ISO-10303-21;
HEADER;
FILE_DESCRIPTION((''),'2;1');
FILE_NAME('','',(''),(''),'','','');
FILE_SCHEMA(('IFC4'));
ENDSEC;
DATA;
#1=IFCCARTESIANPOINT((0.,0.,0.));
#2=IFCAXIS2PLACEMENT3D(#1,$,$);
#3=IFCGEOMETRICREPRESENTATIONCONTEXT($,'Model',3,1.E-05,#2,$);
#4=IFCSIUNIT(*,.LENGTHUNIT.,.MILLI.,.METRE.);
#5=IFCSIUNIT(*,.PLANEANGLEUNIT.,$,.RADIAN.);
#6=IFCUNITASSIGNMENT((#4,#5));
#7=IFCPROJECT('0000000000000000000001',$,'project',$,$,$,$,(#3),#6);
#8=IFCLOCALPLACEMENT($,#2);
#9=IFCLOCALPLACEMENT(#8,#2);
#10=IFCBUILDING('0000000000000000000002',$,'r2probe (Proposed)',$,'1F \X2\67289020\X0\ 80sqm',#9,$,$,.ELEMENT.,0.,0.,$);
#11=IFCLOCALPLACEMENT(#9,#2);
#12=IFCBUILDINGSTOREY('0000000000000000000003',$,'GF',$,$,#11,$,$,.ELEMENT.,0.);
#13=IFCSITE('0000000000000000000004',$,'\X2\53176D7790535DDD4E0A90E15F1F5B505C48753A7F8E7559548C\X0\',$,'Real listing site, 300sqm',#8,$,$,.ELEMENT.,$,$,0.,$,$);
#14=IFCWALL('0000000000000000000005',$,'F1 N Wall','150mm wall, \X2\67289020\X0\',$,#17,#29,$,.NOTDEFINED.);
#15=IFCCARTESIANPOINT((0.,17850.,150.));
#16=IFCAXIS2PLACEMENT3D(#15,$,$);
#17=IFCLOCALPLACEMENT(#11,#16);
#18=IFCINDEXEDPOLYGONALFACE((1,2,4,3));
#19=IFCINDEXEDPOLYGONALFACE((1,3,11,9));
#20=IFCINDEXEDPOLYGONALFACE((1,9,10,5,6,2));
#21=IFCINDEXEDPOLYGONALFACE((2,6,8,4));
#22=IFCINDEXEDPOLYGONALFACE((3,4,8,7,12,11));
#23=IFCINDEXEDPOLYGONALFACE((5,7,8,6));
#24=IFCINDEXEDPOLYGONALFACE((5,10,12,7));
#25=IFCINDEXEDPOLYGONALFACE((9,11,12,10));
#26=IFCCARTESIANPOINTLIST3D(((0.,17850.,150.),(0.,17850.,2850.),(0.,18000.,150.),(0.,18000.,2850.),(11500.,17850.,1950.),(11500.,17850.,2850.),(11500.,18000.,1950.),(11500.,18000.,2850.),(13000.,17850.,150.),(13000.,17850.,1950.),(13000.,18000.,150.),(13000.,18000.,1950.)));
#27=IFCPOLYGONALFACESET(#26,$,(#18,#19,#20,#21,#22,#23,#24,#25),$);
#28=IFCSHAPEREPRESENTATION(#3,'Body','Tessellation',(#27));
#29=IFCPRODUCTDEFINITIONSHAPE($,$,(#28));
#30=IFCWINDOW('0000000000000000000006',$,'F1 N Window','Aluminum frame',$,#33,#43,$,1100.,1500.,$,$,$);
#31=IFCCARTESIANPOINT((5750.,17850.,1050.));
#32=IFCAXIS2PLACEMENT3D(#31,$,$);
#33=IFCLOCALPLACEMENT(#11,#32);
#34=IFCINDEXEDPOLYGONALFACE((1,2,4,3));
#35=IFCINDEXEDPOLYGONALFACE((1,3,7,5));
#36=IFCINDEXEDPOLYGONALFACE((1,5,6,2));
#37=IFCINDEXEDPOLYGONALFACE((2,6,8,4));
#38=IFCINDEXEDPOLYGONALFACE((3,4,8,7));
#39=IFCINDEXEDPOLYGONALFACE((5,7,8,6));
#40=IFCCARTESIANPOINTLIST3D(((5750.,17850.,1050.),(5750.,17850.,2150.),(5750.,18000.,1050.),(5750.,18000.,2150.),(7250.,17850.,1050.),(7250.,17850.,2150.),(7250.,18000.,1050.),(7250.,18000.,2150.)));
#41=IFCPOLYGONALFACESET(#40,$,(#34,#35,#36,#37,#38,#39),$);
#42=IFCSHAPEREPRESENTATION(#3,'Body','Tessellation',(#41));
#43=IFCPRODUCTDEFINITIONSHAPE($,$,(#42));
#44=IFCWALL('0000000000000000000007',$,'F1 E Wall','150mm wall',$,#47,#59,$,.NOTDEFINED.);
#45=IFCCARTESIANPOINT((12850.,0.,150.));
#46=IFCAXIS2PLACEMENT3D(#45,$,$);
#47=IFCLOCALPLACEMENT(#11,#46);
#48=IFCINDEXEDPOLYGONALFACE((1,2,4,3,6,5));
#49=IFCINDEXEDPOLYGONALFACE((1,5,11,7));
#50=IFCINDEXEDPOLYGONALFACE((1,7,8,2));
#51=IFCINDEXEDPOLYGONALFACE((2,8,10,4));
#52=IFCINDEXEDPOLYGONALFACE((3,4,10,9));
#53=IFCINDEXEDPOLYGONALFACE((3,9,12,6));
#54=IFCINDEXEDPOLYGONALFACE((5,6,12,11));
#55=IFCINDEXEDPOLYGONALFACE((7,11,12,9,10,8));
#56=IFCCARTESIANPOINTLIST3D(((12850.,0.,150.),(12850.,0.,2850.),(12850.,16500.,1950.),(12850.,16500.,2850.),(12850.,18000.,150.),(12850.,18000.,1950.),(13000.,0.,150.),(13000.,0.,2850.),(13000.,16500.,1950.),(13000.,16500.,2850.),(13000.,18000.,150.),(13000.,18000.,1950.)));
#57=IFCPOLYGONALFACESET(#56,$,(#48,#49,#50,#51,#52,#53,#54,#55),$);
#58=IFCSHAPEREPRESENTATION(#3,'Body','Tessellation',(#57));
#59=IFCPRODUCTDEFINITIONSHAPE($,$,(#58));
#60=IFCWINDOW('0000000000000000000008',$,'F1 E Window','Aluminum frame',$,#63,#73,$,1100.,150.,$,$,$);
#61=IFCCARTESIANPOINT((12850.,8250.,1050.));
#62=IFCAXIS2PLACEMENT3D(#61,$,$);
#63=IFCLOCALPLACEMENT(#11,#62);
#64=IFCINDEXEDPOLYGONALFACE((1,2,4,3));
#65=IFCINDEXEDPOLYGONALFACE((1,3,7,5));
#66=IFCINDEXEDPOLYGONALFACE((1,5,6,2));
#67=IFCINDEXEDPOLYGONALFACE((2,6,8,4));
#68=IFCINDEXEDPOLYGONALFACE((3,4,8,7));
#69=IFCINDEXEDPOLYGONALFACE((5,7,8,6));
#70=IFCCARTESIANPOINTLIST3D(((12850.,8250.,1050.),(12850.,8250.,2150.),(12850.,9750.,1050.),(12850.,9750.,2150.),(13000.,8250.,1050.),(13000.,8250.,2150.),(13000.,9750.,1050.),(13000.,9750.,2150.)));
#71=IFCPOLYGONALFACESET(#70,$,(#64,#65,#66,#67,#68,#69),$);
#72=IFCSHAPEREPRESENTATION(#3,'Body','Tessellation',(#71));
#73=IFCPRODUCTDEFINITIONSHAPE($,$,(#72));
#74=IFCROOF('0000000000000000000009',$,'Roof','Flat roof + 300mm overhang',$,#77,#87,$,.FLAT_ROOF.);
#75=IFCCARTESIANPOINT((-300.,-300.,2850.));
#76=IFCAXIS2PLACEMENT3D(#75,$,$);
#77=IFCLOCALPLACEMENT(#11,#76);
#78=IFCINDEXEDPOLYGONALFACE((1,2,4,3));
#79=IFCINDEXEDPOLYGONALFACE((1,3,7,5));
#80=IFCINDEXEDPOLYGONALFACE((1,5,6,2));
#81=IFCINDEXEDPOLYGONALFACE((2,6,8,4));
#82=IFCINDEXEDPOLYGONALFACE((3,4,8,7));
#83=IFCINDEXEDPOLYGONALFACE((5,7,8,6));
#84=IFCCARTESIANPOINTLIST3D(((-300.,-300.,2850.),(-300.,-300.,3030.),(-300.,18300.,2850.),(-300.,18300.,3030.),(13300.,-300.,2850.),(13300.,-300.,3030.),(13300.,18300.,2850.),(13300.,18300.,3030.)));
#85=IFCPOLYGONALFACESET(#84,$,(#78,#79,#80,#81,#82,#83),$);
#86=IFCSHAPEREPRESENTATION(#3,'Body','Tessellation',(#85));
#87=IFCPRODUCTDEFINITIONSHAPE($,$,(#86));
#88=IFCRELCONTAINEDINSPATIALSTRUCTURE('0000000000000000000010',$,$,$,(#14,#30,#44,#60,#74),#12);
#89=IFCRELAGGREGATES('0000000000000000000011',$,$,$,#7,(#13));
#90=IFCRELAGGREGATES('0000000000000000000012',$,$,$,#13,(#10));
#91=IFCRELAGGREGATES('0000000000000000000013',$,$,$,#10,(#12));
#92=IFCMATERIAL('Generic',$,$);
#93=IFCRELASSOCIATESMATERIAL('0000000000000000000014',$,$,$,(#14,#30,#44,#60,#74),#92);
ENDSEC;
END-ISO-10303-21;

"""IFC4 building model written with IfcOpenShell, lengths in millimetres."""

from ifc_helpers import new_model, si_unit, frame, frame_2d, origin, place, context, project, spatial, rectangle, extrude, material, element, fill, save


model = new_model("IFC4")

# Units and contexts
model_context = context("Model", 3, precision=1e-05, world=origin())
ifc_project = project(units=[si_unit("LENGTHUNIT", "METRE", prefix="MILLI"), si_unit("PLANEANGLEUNIT", "RADIAN")], contexts=[model_context])

# Site, building, storey
site_placement = place(None, origin())
site = spatial("IfcSite", under=ifc_project, at=site_placement, Name="北海道川上郡弟子屈町美留和", ObjectType="Real listing site, 300sqm", CompositionType="ELEMENT", RefElevation=0.0)
building_placement = place(site_placement, origin())
building = spatial("IfcBuilding", under=site, at=building_placement, Name="r2probe (Proposed)", ObjectType="1F 木造 80sqm", CompositionType="ELEMENT", ElevationOfRefHeight=0.0, ElevationOfTerrain=0.0)
storey_placement = place(building_placement, origin())
storey = spatial("IfcBuildingStorey", under=building, at=storey_placement, Name="GF", CompositionType="ELEMENT", Elevation=0.0)

# Wall, opening, window
ifc_material_1 = material(Name="Generic")
wall_1_placement = place(storey_placement, frame((0.0, 17850.0, 150.0)))
wall_1 = element("IfcWall", 1, at=wall_1_placement, inside=storey, material=ifc_material_1, Name="F1 N Wall", Description="150mm wall, 木造", PredefinedType="NOTDEFINED", context=model_context, shape_type="SweptSolid", body=[
    extrude(rectangle(XDim=13000.0, YDim=150.0, at=frame_2d((6500.0, 75.0))), frame((0.0, 17850.0, 150.0)), (0.0, 0.0, 1.0), 2700.0),
])
opening_1_placement = place(storey_placement, frame((5750.0, 17850.0, 1050.0)))
opening_1 = element("IfcOpeningElement", 2, at=opening_1_placement, cuts=wall_1, PredefinedType="NOTDEFINED", context=model_context, shape_type="SweptSolid", body=[
    extrude(rectangle(XDim=1500.0, YDim=150.0, at=frame_2d((750.0, 75.0))), frame((5750.0, 17850.0, 1050.0)), (0.0, 0.0, 1.0), 1100.0),
])
window_1_placement = place(storey_placement, frame((5750.0, 17850.0, 1050.0)))
window_1 = element("IfcWindow", 3, at=window_1_placement, inside=storey, material=ifc_material_1, Name="F1 N Window", Description="Aluminum frame", OverallHeight=1100.0, OverallWidth=1500.0, context=model_context, shape_type="SweptSolid", body=[
    extrude(rectangle(XDim=1500.0, YDim=150.0, at=frame_2d((750.0, 75.0))), frame((5750.0, 17850.0, 1050.0)), (0.0, 0.0, 1.0), 1100.0),
])
fill(opening_1, window_1)

# Wall, opening, window
wall_2_placement = place(storey_placement, frame((12850.0, 0.0, 150.0)))
wall_2 = element("IfcWall", 4, at=wall_2_placement, inside=storey, material=ifc_material_1, Name="F1 E Wall", Description="150mm wall", PredefinedType="NOTDEFINED", context=model_context, shape_type="SweptSolid", body=[
    extrude(rectangle(XDim=150.0, YDim=18000.0, at=frame_2d((75.0, 9000.0))), frame((12850.0, 0.0, 150.0)), (0.0, 0.0, 1.0), 2700.0),
])
opening_2_placement = place(storey_placement, frame((12850.0, 8250.0, 1050.0)))
opening_2 = element("IfcOpeningElement", 5, at=opening_2_placement, cuts=wall_2, PredefinedType="NOTDEFINED", context=model_context, shape_type="SweptSolid", body=[
    extrude(rectangle(XDim=150.0, YDim=1500.0, at=frame_2d((75.0, 750.0))), frame((12850.0, 8250.0, 1050.0)), (0.0, 0.0, 1.0), 1100.0),
])
window_2_placement = place(storey_placement, frame((12850.0, 8250.0, 1050.0)))
window_2 = element("IfcWindow", 6, at=window_2_placement, inside=storey, material=ifc_material_1, Name="F1 E Window", Description="Aluminum frame", OverallHeight=1100.0, OverallWidth=150.0, context=model_context, shape_type="SweptSolid", body=[
    extrude(rectangle(XDim=150.0, YDim=1500.0, at=frame_2d((75.0, 750.0))), frame((12850.0, 8250.0, 1050.0)), (0.0, 0.0, 1.0), 1100.0),
])
fill(opening_2, window_2)

# Roof
roof_placement = place(storey_placement, frame((-300.0, -300.0, 2850.0)))
element("IfcRoof", 7, at=roof_placement, inside=storey, material=ifc_material_1, Name="Roof", Description="Flat roof + 300mm overhang", PredefinedType="FLAT_ROOF", context=model_context, shape_type="SweptSolid", body=[
    extrude(rectangle(XDim=13600.0, YDim=18600.0, at=frame_2d((6800.0, 9300.0))), frame((-300.0, -300.0, 2850.0)), (0.0, 0.0, 1.0), 180.0),
])

save(model, "model.ifc")
